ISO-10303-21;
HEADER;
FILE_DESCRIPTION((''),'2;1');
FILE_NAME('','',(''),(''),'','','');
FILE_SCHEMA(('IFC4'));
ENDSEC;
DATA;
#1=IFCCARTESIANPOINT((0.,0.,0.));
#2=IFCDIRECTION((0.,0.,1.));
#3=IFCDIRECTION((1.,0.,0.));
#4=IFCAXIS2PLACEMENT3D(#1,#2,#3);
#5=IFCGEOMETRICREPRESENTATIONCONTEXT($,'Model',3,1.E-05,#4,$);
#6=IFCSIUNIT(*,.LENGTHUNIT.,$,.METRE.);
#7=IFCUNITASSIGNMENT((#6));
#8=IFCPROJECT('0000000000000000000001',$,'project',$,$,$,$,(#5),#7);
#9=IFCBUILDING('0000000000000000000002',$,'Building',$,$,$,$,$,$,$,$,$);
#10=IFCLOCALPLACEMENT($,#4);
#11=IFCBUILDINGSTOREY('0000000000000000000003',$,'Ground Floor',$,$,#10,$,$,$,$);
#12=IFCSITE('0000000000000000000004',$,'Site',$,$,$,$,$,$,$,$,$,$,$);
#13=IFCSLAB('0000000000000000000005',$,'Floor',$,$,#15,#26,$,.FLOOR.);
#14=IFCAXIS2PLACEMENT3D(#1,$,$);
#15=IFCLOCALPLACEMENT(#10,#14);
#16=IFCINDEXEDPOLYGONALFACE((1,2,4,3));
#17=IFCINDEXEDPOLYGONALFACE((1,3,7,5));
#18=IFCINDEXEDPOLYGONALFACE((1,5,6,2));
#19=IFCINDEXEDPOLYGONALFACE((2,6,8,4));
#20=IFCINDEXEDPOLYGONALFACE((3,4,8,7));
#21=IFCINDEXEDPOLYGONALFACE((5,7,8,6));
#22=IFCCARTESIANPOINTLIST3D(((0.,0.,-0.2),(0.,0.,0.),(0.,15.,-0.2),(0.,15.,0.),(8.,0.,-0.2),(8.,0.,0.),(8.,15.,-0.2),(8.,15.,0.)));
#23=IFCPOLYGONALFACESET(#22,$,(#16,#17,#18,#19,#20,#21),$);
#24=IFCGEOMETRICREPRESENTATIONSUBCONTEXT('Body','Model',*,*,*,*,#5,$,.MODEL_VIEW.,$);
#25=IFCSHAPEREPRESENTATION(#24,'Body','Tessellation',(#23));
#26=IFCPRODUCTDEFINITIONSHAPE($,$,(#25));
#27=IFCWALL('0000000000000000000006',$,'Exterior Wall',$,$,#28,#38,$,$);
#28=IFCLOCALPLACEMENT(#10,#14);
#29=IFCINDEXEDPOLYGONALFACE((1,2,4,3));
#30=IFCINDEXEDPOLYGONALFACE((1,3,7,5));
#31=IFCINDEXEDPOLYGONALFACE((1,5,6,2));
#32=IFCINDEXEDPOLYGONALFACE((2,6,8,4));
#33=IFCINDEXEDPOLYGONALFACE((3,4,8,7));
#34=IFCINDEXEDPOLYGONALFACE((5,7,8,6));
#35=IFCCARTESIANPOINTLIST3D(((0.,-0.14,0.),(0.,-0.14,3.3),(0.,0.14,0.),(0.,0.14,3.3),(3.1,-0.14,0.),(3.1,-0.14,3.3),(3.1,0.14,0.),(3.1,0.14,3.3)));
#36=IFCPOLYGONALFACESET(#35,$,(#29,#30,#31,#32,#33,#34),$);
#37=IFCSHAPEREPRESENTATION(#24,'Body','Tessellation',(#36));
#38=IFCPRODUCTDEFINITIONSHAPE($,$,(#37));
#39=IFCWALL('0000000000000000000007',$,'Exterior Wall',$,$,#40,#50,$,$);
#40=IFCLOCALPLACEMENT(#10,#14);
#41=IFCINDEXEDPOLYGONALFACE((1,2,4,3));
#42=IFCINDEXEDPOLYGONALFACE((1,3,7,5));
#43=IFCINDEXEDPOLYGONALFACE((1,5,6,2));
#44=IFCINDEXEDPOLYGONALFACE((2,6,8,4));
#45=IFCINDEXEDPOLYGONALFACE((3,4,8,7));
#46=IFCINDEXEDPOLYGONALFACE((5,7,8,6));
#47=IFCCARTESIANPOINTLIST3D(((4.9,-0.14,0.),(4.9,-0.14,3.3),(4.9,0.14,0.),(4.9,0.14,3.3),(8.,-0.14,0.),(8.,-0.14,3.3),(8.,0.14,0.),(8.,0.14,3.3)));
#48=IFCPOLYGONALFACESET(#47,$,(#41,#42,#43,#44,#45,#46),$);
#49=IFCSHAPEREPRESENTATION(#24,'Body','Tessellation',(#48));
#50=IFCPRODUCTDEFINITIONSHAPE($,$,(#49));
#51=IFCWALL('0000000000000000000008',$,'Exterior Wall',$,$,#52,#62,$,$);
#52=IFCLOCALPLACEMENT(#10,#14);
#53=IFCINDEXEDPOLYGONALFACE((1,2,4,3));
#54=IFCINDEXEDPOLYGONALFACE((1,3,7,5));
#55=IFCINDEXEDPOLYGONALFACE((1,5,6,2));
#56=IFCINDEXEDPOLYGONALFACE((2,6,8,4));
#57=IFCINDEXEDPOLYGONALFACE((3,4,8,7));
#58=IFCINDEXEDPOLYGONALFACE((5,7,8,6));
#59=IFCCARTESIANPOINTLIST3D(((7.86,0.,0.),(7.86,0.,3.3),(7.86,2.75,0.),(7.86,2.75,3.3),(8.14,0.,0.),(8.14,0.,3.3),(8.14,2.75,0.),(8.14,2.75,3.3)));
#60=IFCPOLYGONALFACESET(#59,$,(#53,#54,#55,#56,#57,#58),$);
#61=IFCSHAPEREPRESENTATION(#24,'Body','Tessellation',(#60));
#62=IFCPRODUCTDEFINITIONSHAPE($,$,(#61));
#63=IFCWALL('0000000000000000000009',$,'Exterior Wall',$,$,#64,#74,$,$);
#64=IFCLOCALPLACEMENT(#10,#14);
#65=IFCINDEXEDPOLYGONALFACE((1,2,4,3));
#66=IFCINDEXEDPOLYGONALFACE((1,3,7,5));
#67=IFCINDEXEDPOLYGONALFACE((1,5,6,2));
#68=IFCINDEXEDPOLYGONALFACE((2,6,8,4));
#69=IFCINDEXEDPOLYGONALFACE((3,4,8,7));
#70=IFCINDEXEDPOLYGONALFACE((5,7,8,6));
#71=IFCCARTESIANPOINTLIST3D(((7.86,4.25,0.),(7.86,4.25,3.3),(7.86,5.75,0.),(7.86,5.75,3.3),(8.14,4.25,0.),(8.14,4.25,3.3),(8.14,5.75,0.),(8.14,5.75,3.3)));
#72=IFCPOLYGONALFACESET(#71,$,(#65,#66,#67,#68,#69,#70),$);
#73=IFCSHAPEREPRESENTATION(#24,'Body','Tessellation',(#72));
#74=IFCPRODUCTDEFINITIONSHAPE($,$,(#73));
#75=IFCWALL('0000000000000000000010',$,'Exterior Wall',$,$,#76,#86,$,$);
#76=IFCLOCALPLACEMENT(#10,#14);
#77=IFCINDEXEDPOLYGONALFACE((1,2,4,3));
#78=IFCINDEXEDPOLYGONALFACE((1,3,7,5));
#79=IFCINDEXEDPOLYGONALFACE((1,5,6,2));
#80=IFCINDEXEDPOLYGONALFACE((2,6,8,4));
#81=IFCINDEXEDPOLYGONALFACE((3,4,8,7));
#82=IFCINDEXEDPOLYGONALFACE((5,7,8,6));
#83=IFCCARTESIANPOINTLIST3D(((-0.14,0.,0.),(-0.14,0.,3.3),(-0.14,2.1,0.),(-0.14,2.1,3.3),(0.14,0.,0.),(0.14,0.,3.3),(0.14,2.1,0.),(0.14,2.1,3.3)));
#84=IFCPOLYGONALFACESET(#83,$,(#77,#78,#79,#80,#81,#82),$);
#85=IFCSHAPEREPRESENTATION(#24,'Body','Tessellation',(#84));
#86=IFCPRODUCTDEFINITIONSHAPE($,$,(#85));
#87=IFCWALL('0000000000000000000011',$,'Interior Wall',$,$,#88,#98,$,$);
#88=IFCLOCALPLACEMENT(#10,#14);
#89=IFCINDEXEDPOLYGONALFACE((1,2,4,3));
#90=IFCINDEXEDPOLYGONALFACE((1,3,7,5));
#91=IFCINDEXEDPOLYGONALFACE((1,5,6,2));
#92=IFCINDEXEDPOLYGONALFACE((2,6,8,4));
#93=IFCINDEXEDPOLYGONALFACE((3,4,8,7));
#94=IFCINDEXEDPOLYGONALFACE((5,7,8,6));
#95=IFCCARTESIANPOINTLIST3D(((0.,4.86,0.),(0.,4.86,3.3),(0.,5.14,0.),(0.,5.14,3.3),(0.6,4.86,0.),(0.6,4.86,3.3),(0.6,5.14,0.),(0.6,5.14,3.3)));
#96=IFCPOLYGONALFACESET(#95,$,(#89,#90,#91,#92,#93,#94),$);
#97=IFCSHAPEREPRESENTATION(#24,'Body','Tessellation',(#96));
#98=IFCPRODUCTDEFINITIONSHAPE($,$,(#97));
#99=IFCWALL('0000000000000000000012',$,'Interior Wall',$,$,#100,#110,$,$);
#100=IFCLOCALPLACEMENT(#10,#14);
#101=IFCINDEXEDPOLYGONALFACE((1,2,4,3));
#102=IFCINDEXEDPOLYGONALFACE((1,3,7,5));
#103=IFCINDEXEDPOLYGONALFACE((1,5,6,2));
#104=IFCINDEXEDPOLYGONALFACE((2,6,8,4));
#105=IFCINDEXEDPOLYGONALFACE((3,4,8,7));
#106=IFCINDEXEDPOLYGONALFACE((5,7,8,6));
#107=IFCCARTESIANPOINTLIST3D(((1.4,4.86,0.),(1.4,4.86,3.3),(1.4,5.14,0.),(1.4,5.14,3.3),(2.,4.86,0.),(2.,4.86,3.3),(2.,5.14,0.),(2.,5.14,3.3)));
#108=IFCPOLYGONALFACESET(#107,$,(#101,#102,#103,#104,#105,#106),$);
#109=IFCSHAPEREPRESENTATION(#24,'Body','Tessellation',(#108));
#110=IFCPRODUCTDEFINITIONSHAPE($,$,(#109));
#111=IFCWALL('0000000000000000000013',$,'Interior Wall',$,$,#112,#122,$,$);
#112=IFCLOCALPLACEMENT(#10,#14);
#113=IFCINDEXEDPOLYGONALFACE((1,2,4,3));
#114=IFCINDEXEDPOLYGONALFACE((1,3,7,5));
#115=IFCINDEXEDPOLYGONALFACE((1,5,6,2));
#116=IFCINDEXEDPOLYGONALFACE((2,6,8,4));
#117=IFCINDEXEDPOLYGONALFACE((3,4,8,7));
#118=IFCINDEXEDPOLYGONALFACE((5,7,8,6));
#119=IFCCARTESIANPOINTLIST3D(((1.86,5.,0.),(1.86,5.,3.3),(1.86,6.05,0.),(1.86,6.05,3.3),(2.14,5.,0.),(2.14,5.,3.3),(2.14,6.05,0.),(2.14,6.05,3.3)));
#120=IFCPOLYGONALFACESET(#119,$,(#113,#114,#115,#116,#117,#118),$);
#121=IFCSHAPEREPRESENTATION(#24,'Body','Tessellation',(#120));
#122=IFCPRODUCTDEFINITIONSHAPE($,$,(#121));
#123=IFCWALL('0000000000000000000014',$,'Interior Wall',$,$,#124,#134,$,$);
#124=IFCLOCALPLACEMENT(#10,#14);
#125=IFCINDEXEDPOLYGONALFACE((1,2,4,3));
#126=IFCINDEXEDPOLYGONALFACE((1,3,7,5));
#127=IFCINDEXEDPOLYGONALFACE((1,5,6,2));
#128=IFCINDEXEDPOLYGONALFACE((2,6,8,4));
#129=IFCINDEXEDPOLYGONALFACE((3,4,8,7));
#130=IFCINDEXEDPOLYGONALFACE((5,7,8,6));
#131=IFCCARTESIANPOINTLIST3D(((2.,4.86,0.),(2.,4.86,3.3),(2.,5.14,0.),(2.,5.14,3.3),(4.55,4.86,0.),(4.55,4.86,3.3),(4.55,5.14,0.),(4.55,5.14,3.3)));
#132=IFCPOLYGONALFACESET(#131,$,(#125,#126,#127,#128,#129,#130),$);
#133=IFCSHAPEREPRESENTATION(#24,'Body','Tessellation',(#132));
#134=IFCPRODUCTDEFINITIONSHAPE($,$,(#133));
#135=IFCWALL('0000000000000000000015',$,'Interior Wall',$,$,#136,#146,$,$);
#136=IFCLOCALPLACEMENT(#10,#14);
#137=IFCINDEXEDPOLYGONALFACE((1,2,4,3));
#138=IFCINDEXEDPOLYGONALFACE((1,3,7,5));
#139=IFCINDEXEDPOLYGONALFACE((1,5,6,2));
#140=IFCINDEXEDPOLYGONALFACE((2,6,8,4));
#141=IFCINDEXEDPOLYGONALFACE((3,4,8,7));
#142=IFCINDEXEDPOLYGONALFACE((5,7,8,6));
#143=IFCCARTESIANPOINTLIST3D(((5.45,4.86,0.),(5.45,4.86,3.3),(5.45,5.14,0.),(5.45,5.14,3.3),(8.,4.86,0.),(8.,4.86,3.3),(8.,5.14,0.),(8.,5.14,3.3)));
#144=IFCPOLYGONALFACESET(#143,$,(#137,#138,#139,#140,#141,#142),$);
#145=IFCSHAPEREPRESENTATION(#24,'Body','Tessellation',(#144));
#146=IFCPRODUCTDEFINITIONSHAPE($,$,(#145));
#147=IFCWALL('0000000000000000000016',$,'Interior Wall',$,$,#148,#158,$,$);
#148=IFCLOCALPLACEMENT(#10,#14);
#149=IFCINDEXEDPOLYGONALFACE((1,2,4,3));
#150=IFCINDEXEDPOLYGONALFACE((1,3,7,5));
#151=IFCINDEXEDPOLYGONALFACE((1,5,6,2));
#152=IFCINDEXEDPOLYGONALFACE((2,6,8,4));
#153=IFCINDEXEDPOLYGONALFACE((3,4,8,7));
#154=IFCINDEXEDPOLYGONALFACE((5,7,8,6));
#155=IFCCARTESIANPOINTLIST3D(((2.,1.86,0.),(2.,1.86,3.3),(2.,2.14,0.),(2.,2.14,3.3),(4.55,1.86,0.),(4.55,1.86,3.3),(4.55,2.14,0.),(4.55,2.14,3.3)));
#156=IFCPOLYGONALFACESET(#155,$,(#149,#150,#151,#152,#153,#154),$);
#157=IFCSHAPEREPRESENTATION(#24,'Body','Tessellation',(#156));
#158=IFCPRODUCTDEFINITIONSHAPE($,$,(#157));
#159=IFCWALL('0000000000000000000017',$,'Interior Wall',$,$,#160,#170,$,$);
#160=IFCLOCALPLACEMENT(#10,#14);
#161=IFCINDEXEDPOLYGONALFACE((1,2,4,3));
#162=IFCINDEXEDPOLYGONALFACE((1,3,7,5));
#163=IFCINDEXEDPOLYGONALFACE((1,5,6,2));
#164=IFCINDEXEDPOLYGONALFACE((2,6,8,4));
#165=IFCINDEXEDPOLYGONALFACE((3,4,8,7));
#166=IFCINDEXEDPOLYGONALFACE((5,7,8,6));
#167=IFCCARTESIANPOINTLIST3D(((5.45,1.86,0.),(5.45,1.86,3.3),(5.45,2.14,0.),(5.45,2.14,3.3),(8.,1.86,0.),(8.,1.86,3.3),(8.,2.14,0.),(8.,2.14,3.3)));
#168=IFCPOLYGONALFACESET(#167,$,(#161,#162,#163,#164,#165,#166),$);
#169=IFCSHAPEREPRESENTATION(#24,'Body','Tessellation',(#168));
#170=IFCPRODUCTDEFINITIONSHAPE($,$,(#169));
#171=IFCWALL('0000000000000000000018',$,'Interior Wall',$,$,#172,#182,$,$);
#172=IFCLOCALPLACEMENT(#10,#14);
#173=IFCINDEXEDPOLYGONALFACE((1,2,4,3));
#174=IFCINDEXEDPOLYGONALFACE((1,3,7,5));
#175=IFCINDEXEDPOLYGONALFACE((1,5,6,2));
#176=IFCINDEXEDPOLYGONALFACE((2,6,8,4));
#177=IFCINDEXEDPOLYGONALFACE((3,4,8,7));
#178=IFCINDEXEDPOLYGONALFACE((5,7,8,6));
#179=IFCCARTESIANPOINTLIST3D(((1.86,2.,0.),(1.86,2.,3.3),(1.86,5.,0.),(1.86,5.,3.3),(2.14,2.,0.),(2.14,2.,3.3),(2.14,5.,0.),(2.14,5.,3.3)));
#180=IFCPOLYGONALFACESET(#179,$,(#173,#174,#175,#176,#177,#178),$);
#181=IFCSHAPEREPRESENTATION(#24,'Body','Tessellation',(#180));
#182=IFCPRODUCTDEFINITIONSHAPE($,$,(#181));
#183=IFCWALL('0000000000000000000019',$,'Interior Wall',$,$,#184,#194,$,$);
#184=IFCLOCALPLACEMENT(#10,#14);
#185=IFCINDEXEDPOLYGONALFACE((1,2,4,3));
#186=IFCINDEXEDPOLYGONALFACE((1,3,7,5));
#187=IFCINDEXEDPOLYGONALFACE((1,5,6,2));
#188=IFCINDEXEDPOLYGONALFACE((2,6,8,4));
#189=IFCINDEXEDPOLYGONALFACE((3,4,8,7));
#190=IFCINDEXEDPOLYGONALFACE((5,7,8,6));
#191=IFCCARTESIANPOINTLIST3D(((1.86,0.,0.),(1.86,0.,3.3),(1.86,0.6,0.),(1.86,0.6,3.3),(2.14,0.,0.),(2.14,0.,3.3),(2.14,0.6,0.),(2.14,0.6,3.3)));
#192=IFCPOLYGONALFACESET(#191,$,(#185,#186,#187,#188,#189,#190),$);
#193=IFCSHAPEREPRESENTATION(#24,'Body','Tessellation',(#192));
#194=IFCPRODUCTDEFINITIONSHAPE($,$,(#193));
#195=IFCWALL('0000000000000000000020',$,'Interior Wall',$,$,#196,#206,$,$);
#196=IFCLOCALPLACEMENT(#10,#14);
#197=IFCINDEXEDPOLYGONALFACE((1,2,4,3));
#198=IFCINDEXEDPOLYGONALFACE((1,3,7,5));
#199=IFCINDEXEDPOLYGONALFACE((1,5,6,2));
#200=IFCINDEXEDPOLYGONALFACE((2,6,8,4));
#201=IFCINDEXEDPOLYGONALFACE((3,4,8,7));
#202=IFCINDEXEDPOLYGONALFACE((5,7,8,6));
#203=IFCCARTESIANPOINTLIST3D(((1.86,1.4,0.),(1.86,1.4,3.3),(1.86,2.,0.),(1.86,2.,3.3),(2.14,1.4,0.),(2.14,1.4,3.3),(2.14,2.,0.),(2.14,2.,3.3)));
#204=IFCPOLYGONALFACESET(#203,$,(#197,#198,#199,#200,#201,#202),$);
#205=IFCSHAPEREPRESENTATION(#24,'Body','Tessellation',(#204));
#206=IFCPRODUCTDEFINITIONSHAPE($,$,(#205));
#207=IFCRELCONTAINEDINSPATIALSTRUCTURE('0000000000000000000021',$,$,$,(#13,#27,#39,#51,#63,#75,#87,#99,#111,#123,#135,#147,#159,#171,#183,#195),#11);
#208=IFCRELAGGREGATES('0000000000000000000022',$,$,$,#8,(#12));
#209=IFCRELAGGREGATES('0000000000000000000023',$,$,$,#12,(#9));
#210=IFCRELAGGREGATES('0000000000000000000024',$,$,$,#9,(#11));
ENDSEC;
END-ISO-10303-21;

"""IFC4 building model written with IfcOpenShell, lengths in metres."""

from ifc_helpers import new_model, si_unit, frame, origin_with_axes, place, context, subcontext, project, spatial, indexed_curve, outline, extrude, element, save


model = new_model("IFC4")

# Units and contexts
model_context = context("Model", 3, precision=1e-05, world=origin_with_axes())
body_context = subcontext(model_context, "Body", "Model", "MODEL_VIEW")
ifc_project = project(units=[si_unit("LENGTHUNIT", "METRE")], contexts=[model_context])

# Site, building, storey
site = spatial("IfcSite", under=ifc_project, Name="Site")
building = spatial("IfcBuilding", under=site, Name="Building")
storey_placement = place(None, origin_with_axes())
storey = spatial("IfcBuildingStorey", under=building, at=storey_placement, Name="Ground Floor")

# Slab
slab_placement = place(storey_placement, frame((0.0, 0.0, -0.2), z_axis=(0.0, 0.0, 1.0), x_axis=(1.0, 0.0, 0.0)))
element("IfcSlab", 1, at=slab_placement, inside=storey, Name="Floor", PredefinedType="FLOOR", context=body_context, shape_type="SweptSolid", body=[
    extrude(outline(indexed_curve([(0.0, 0.0), (8.0, 0.0), (8.0, 15.0), (0.0, 15.0)])), None, (0.0, 0.0, 1.0), 0.2),
])

# Walls
wall_1_placement = place(storey_placement, origin_with_axes())
element("IfcWall", 2, at=wall_1_placement, inside=storey, Name="Exterior Wall", context=body_context, shape_type="SweptSolid", body=[
    extrude(outline(indexed_curve([(0.0, 0.0), (0.0, 0.28), (3.1, 0.28), (3.1, 0.0), (0.0, 0.0)], self_intersect=False)), frame((0.0, -0.14, 0.0), z_axis=(0.0, 0.0, 1.0), x_axis=(1.0, 0.0, 0.0)), (0.0, 0.0, 1.0), 3.3),
])
wall_2_placement = place(storey_placement, frame((4.9, 0.0, 0.0), z_axis=(0.0, 0.0, 1.0), x_axis=(1.0, 0.0, 0.0)))
element("IfcWall", 3, at=wall_2_placement, inside=storey, Name="Exterior Wall", context=body_context, shape_type="SweptSolid", body=[
    extrude(outline(indexed_curve([(0.0, 0.0), (0.0, 0.28), (3.1, 0.28), (3.1, 0.0), (0.0, 0.0)], self_intersect=False)), frame((0.0, -0.14, 0.0), z_axis=(0.0, 0.0, 1.0), x_axis=(1.0, 0.0, 0.0)), (0.0, 0.0, 1.0), 3.3),
])
wall_3_placement = place(storey_placement, frame((8.0, 0.0, 0.0), z_axis=(0.0, 0.0, 1.0), x_axis=(0.0, 1.0, 0.0)))
element("IfcWall", 4, at=wall_3_placement, inside=storey, Name="Exterior Wall", context=body_context, shape_type="SweptSolid", body=[
    extrude(outline(indexed_curve([(0.0, 0.0), (0.0, 0.28), (2.75, 0.28), (2.75, 0.0), (0.0, 0.0)], self_intersect=False)), frame((0.0, -0.14, 0.0), z_axis=(0.0, 0.0, 1.0), x_axis=(1.0, 0.0, 0.0)), (0.0, 0.0, 1.0), 3.3),
])
wall_4_placement = place(storey_placement, frame((8.0, 4.25, 0.0), z_axis=(0.0, 0.0, 1.0), x_axis=(0.0, 1.0, 0.0)))
element("IfcWall", 5, at=wall_4_placement, inside=storey, Name="Exterior Wall", context=body_context, shape_type="SweptSolid", body=[
    extrude(outline(indexed_curve([(0.0, 0.0), (0.0, 0.28), (1.5, 0.28), (1.5, 0.0), (0.0, 0.0)], self_intersect=False)), frame((0.0, -0.14, 0.0), z_axis=(0.0, 0.0, 1.0), x_axis=(1.0, 0.0, 0.0)), (0.0, 0.0, 1.0), 3.3),
])
wall_5_placement = place(storey_placement, frame((0.0, 2.1, 0.0), z_axis=(0.0, 0.0, 1.0), x_axis=(0.0, -1.0, 0.0)))
element("IfcWall", 6, at=wall_5_placement, inside=storey, Name="Exterior Wall", context=body_context, shape_type="SweptSolid", body=[
    extrude(outline(indexed_curve([(0.0, 0.0), (0.0, 0.28), (2.1, 0.28), (2.1, 0.0), (0.0, 0.0)], self_intersect=False)), frame((0.0, -0.14, 0.0), z_axis=(0.0, 0.0, 1.0), x_axis=(1.0, 0.0, 0.0)), (0.0, 0.0, 1.0), 3.3),
])
wall_6_placement = place(storey_placement, frame((0.0, 5.0, 0.0), z_axis=(0.0, 0.0, 1.0), x_axis=(1.0, 0.0, 0.0)))
element("IfcWall", 7, at=wall_6_placement, inside=storey, Name="Interior Wall", context=body_context, shape_type="SweptSolid", body=[
    extrude(outline(indexed_curve([(0.0, 0.0), (0.0, 0.28), (0.6, 0.28), (0.6, 0.0), (0.0, 0.0)], self_intersect=False)), frame((0.0, -0.14, 0.0), z_axis=(0.0, 0.0, 1.0), x_axis=(1.0, 0.0, 0.0)), (0.0, 0.0, 1.0), 3.3),
])
wall_7_placement = place(storey_placement, frame((1.4, 5.0, 0.0), z_axis=(0.0, 0.0, 1.0), x_axis=(1.0, 0.0, 0.0)))
element("IfcWall", 8, at=wall_7_placement, inside=storey, Name="Interior Wall", context=body_context, shape_type="SweptSolid", body=[
    extrude(outline(indexed_curve([(0.0, 0.0), (0.0, 0.28), (0.6, 0.28), (0.6, 0.0), (0.0, 0.0)], self_intersect=False)), frame((0.0, -0.14, 0.0), z_axis=(0.0, 0.0, 1.0), x_axis=(1.0, 0.0, 0.0)), (0.0, 0.0, 1.0), 3.3),
])
wall_8_placement = place(storey_placement, frame((2.0, 5.0, 0.0), z_axis=(0.0, 0.0, 1.0), x_axis=(0.0, 1.0, 0.0)))
element("IfcWall", 9, at=wall_8_placement, inside=storey, Name="Interior Wall", context=body_context, shape_type="SweptSolid", body=[
    extrude(outline(indexed_curve([(0.0, 0.0), (0.0, 0.28), (1.05, 0.28), (1.05, 0.0), (0.0, 0.0)], self_intersect=False)), frame((0.0, -0.14, 0.0), z_axis=(0.0, 0.0, 1.0), x_axis=(1.0, 0.0, 0.0)), (0.0, 0.0, 1.0), 3.3),
])
for number, where, z_axis, x_axis, name in (
    (10, (2.0, 5.0, 0.0), (0.0, 0.0, 1.0), (1.0, 0.0, 0.0), "Interior Wall"),
    (11, (5.45, 5.0, 0.0), (0.0, 0.0, 1.0), (1.0, 0.0, 0.0), "Interior Wall"),
    (12, (2.0, 2.0, 0.0), (0.0, 0.0, 1.0), (1.0, 0.0, 0.0), "Interior Wall"),
    (13, (5.45, 2.0, 0.0), (0.0, 0.0, 1.0), (1.0, 0.0, 0.0), "Interior Wall"),
):
    element("IfcWall", number, at=place(storey_placement, frame(where, z_axis=z_axis, x_axis=x_axis)), inside=storey, Name=name, context=body_context, shape_type="SweptSolid", body=[
        extrude(outline(indexed_curve([(0.0, 0.0), (0.0, 0.28), (2.55, 0.28), (2.55, 0.0), (0.0, 0.0)], self_intersect=False)), frame((0.0, -0.14, 0.0), z_axis=(0.0, 0.0, 1.0), x_axis=(1.0, 0.0, 0.0)), (0.0, 0.0, 1.0), 3.3),
    ])
wall_9_placement = place(storey_placement, frame((2.0, 5.0, 0.0), z_axis=(0.0, 0.0, 1.0), x_axis=(0.0, -1.0, 0.0)))
element("IfcWall", 14, at=wall_9_placement, inside=storey, Name="Interior Wall", context=body_context, shape_type="SweptSolid", body=[
    extrude(outline(indexed_curve([(0.0, 0.0), (0.0, 0.28), (3.0, 0.28), (3.0, 0.0), (0.0, 0.0)], self_intersect=False)), frame((0.0, -0.14, 0.0), z_axis=(0.0, 0.0, 1.0), x_axis=(1.0, 0.0, 0.0)), (0.0, 0.0, 1.0), 3.3),
])
wall_10_placement = place(storey_placement, frame((2.0, 0.0, 0.0), z_axis=(0.0, 0.0, 1.0), x_axis=(0.0, 1.0, 0.0)))
element("IfcWall", 15, at=wall_10_placement, inside=storey, Name="Interior Wall", context=body_context, shape_type="SweptSolid", body=[
    extrude(outline(indexed_curve([(0.0, 0.0), (0.0, 0.28), (0.6, 0.28), (0.6, 0.0), (0.0, 0.0)], self_intersect=False)), frame((0.0, -0.14, 0.0), z_axis=(0.0, 0.0, 1.0), x_axis=(1.0, 0.0, 0.0)), (0.0, 0.0, 1.0), 3.3),
])
wall_11_placement = place(storey_placement, frame((2.0, 1.4, 0.0), z_axis=(0.0, 0.0, 1.0), x_axis=(0.0, 1.0, 0.0)))
element("IfcWall", 16, at=wall_11_placement, inside=storey, Name="Interior Wall", context=body_context, shape_type="SweptSolid", body=[
    extrude(outline(indexed_curve([(0.0, 0.0), (0.0, 0.28), (0.6, 0.28), (0.6, 0.0), (0.0, 0.0)], self_intersect=False)), frame((0.0, -0.14, 0.0), z_axis=(0.0, 0.0, 1.0), x_axis=(1.0, 0.0, 0.0)), (0.0, 0.0, 1.0), 3.3),
])

save(model, "model.ifc")
